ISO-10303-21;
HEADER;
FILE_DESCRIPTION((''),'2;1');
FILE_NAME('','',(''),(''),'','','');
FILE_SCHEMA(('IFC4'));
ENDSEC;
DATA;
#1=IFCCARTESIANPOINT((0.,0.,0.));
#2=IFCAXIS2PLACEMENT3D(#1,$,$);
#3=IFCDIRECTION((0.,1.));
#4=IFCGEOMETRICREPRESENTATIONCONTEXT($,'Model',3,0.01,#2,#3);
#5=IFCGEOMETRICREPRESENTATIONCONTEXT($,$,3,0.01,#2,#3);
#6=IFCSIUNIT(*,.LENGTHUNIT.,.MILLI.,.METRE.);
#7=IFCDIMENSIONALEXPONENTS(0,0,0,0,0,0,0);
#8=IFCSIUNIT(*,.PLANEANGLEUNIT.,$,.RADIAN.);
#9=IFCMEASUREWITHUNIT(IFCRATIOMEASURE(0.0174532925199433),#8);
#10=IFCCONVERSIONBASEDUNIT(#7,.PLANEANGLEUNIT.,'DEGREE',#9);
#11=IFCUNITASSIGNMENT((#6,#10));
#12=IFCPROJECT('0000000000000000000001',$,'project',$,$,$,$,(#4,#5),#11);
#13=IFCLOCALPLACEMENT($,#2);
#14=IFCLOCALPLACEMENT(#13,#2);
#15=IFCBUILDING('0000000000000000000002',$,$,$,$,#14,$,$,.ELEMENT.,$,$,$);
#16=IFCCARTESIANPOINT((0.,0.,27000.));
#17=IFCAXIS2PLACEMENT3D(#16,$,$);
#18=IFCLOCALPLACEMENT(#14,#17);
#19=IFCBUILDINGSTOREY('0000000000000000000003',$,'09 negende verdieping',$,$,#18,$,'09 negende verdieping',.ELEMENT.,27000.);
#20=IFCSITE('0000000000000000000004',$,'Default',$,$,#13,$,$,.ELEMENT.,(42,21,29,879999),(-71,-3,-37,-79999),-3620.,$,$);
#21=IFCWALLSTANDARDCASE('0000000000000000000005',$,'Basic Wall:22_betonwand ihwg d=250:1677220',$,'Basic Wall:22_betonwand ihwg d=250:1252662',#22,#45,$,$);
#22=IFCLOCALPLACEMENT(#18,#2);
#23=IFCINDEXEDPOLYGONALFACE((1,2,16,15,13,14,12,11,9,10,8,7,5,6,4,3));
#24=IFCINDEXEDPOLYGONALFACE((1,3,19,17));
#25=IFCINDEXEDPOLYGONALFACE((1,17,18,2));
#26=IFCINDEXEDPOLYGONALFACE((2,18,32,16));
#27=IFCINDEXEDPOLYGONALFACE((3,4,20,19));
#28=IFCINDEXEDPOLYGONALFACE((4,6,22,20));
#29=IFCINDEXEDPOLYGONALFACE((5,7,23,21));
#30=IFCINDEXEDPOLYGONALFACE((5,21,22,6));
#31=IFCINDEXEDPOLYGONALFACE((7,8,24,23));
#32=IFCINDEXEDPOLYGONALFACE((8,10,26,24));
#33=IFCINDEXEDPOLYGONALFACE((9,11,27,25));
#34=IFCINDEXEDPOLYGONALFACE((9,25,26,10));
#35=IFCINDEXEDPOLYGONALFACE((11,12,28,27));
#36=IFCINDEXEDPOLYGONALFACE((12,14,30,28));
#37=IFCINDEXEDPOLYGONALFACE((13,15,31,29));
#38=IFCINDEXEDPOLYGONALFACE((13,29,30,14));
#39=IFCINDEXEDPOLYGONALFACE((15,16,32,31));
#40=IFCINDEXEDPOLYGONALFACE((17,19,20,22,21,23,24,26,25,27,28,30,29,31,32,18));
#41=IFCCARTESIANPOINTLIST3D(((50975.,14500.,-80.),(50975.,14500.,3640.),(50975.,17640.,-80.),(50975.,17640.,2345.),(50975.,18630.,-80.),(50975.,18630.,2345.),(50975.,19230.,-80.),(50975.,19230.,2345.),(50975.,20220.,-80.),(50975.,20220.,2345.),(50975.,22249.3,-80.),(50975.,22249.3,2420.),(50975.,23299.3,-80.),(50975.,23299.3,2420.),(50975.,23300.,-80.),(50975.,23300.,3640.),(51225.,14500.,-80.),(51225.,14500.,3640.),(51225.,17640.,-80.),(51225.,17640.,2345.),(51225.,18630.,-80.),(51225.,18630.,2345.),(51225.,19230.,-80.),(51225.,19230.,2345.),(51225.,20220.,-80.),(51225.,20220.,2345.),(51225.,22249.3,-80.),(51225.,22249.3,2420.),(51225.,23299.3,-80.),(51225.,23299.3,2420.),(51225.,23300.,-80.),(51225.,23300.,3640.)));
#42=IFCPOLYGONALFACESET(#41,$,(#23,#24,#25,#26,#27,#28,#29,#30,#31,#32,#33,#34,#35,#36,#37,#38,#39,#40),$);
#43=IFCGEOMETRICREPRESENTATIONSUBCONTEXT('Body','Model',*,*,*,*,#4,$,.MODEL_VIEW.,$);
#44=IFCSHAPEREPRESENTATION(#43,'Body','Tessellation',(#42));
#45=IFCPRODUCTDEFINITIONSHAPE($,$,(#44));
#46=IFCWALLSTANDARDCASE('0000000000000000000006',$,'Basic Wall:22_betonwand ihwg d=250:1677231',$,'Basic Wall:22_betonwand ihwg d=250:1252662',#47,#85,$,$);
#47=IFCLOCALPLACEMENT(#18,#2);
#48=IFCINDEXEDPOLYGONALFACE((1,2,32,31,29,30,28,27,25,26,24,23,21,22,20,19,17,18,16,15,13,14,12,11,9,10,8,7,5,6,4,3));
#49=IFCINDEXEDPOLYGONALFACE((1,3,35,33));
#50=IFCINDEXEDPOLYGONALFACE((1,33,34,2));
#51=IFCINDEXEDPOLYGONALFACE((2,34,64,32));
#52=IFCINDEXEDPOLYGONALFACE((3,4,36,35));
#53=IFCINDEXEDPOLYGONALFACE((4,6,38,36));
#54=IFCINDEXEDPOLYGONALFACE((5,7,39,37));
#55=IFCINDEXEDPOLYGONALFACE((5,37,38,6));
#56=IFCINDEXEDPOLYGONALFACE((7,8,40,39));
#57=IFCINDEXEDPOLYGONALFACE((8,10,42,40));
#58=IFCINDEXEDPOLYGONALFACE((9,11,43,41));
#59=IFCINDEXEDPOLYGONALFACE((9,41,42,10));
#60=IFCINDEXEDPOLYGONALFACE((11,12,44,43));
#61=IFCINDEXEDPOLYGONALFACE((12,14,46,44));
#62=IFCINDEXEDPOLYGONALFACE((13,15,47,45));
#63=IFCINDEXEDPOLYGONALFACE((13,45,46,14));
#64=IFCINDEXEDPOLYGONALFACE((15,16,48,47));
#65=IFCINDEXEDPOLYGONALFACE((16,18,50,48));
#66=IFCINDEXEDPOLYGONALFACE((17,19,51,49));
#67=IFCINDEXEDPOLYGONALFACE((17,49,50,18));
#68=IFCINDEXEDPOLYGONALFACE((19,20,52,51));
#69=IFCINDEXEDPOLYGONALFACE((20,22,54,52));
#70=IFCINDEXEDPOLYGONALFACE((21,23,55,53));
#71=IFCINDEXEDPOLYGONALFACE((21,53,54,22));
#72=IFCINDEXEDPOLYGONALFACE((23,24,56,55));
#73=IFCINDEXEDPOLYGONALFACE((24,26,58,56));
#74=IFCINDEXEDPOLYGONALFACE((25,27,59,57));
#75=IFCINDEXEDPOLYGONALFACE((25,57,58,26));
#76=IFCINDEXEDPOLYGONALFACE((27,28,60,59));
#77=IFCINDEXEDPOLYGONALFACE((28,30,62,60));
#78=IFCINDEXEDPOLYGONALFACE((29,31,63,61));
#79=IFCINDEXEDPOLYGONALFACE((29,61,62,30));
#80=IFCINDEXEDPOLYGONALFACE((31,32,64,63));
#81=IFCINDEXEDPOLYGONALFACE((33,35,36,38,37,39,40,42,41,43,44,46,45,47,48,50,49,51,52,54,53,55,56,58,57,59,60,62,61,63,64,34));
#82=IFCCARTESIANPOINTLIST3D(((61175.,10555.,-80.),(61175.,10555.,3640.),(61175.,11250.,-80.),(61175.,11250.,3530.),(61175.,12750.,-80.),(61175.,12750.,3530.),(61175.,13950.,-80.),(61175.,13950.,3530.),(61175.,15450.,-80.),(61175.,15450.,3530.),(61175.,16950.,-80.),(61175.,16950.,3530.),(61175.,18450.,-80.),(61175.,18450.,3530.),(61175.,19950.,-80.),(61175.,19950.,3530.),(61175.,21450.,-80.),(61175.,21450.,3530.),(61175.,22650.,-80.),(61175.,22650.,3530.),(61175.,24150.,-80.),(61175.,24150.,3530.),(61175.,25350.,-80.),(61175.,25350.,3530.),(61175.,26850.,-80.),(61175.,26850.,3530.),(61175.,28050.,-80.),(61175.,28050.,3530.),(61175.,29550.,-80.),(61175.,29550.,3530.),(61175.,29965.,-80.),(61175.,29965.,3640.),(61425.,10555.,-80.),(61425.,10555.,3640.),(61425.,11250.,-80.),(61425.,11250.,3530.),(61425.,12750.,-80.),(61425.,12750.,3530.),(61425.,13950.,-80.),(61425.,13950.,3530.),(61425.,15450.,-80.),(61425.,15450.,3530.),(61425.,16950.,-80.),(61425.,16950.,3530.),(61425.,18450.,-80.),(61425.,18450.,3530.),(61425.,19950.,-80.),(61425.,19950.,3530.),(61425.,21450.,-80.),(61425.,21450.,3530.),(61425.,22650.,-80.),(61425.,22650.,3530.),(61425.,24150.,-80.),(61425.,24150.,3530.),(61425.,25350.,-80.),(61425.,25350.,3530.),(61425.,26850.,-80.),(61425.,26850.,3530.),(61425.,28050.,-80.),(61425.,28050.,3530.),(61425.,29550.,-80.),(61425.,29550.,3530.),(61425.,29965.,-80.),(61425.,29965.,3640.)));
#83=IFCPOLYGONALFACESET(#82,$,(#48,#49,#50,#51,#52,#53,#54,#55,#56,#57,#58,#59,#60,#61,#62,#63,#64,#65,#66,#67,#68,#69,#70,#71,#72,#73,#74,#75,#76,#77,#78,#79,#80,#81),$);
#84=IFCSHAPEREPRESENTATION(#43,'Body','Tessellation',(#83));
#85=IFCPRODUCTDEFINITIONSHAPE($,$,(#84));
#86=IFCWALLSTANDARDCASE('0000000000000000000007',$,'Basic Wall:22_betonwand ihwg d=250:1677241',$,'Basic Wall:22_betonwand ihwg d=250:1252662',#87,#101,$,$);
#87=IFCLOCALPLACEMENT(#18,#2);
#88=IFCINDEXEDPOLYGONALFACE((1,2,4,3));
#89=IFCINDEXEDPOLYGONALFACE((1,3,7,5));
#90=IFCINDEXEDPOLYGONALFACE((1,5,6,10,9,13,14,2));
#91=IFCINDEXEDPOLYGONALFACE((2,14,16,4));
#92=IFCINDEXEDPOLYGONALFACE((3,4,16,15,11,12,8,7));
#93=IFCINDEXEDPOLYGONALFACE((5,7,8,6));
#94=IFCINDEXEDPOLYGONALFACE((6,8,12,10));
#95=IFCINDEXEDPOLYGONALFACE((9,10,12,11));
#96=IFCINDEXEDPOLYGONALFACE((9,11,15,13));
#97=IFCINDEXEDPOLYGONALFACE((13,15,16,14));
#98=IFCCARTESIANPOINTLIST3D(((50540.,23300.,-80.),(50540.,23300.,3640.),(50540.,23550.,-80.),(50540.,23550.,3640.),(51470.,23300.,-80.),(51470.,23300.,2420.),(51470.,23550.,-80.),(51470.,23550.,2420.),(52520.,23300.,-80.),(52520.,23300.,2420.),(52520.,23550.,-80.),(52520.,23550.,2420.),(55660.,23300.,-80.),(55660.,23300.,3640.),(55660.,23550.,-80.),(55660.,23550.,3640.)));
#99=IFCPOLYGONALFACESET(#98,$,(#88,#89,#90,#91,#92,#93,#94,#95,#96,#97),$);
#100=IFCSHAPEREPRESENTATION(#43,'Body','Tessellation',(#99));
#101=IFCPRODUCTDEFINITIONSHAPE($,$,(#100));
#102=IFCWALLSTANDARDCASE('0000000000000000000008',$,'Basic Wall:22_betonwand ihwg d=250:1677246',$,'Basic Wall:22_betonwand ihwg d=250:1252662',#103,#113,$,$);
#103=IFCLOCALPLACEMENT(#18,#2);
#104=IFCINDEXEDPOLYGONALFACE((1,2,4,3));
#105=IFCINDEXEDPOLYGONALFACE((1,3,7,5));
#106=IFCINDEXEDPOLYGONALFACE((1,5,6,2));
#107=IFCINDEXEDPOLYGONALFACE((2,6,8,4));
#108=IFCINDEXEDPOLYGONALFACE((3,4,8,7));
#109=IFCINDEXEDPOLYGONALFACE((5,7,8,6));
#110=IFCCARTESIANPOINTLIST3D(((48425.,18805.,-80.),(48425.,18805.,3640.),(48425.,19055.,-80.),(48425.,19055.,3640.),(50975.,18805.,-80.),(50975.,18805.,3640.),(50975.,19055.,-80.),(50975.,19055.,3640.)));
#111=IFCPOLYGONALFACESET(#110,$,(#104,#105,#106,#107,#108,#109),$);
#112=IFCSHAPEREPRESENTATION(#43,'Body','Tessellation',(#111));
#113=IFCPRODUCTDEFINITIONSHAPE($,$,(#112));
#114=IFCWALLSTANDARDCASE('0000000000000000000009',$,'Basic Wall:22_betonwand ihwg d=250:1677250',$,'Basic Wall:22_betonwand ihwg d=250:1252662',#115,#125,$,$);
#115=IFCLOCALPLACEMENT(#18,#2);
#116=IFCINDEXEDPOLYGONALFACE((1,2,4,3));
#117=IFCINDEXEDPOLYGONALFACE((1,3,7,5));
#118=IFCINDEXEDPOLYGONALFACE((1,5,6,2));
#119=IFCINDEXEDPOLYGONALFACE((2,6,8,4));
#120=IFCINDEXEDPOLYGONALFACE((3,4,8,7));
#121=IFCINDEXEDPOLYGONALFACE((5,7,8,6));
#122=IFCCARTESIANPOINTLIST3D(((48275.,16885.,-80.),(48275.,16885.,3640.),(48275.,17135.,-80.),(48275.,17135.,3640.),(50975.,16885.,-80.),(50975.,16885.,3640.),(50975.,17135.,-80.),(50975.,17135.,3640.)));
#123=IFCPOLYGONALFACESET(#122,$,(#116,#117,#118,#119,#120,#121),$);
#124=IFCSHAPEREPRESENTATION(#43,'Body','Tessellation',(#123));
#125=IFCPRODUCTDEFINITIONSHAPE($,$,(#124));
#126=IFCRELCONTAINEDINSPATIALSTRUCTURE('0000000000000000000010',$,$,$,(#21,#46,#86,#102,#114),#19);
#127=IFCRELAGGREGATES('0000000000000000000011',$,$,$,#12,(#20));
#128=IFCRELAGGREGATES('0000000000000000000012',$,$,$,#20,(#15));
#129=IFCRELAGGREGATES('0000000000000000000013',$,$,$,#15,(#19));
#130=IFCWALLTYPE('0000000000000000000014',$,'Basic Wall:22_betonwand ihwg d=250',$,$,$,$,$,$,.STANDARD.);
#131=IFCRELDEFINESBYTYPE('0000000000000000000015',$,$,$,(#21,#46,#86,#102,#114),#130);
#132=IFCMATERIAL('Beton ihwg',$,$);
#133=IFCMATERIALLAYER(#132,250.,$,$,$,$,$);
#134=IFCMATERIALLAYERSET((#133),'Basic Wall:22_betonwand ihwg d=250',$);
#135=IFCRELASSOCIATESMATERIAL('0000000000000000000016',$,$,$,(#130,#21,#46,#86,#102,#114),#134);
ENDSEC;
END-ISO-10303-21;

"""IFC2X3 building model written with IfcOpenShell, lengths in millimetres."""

from ifc_helpers import new_model, entity, si_unit, converted_unit, direction, frame, frame_2d, origin, place, context, subcontext, project, spatial, rectangle, extrude, material, layer, layer_set, layer_usage, type_object, element, save


model = new_model("IFC2X3")

# Units and contexts
model_context = context("Model", 3, precision=0.01, world=origin(), true_north=direction((0.0, 1.0)))
context_of_model = context(None, 3, precision=0.01, world=origin(), true_north=direction((0.0, 1.0)))
body_context = subcontext(model_context, "Body", "Model", "MODEL_VIEW")
ifc_project = project(units=[si_unit("LENGTHUNIT", "METRE", prefix="MILLI"), converted_unit("PLANEANGLEUNIT", "DEGREE", entity("IfcRatioMeasure", 0.0174532925199433), si_unit("PLANEANGLEUNIT", "RADIAN"), dimensions=[0, 0, 0, 0, 0, 0, 0])], contexts=[model_context, context_of_model])

# Site, building, storey
site_placement = place(None, origin())
site = spatial("IfcSite", under=ifc_project, at=site_placement, Name="Default", CompositionType="ELEMENT", RefLatitude=(42, 21, 29, 879999), RefLongitude=(-71, -3, -37, -79999), RefElevation=-3620.0)
building_placement = place(site_placement, origin())
building = spatial("IfcBuilding", under=site, at=building_placement, CompositionType="ELEMENT")
storey_placement = place(building_placement, frame((0.0, 0.0, 27000.0)))
storey = spatial("IfcBuildingStorey", under=building, at=storey_placement, Name="09 negende verdieping", LongName="09 negende verdieping", CompositionType="ELEMENT", Elevation=27000.0)

# Walls, openings
ifc_material_1 = material(Name="Beton ihwg")
ifc_layer_1 = layer(ifc_material_1, 250.0)
ifc_layer_set_1 = layer_set([ifc_layer_1], Name="Basic Wall:22_betonwand ihwg d=250")
ifc_layer_usage_1 = layer_usage(ifc_layer_set_1, "AXIS2", "NEGATIVE", 125.0)
wall_type_1 = type_object("IfcWallType", Name="Basic Wall:22_betonwand ihwg d=250", PredefinedType="STANDARD", material=ifc_layer_set_1)
wall_1_placement = place(storey_placement, frame((51100.0, 23300.0, -80.0), z_axis=(0.0, 0.0, 1.0), x_axis=(0.0, -1.0, 0.0)))
wall_1 = element("IfcWallStandardCase", 1, at=wall_1_placement, inside=storey, type_object=wall_type_1, material=ifc_layer_usage_1, Name="Basic Wall:22_betonwand ihwg d=250:1677220", ObjectType="Basic Wall:22_betonwand ihwg d=250:1252662", context=body_context, shape_type="SweptSolid", body=[
    extrude(rectangle(XDim=8800.0, YDim=250.0, at=frame_2d((4400.0, 0.0), x_axis=(-1.0, 0.0))), origin(), (0.0, 0.0, 1.0), 3720.0),
])
opening_1_placement = place(wall_1_placement, frame((23300.0, -51100.0, 80.0), z_axis=(0.0, 0.0, 1.0), x_axis=(0.0, 1.0, 0.0)))
element("IfcOpeningElement", 2, at=opening_1_placement, cuts=wall_1, ObjectType="Opening", context=body_context, shape_type="SweptSolid", body=[
    extrude(rectangle(XDim=2425.0, YDim=990.0, at=frame_2d((0.0, 0.0), x_axis=(1.0, 0.0))), frame((50700.0, 19725.0, 1132.5), z_axis=(1.0, 0.0, 0.0), x_axis=(0.0, 0.0, -1.0)), (0.0, 0.0, 1.0), 800.0),
])
opening_2_placement = place(wall_1_placement, frame((23300.0, -51100.0, 80.0), z_axis=(0.0, 0.0, 1.0), x_axis=(0.0, 1.0, 0.0)))
element("IfcOpeningElement", 3, at=opening_2_placement, cuts=wall_1, ObjectType="Opening", context=body_context, shape_type="SweptSolid", body=[
    extrude(rectangle(XDim=2425.0, YDim=990.0, at=frame_2d((0.0, 0.0), x_axis=(1.0, 0.0))), frame((50700.0, 18135.0, 1132.5), z_axis=(1.0, 0.0, 0.0), x_axis=(0.0, 0.0, -1.0)), (0.0, 0.0, 1.0), 800.0),
])
opening_3_placement = place(wall_1_placement, frame((23300.0, -51100.0, 80.0), z_axis=(0.0, 0.0, 1.0), x_axis=(0.0, 1.0, 0.0)))
element("IfcOpeningElement", 4, at=opening_3_placement, cuts=wall_1, ObjectType="Opening", context=body_context, shape_type="SweptSolid", body=[
    extrude(rectangle(XDim=2500.0, YDim=1050.0, at=frame_2d((0.0, 0.0), x_axis=(1.0, 0.0))), frame((50700.0, 22774.3, 1170.0), z_axis=(1.0, 0.0, 0.0), x_axis=(0.0, 0.0, -1.0)), (0.0, 0.0, 1.0), 800.0),
])
ifc_layer_usage_2 = layer_usage(ifc_layer_set_1, "AXIS2", "POSITIVE", -125.0)
wall_2_placement = place(storey_placement, frame((61300.0, 29965.0, -80.0), z_axis=(0.0, 0.0, 1.0), x_axis=(0.0, -1.0, 0.0)))
wall_2 = element("IfcWallStandardCase", 5, at=wall_2_placement, inside=storey, type_object=wall_type_1, material=ifc_layer_usage_2, Name="Basic Wall:22_betonwand ihwg d=250:1677231", ObjectType="Basic Wall:22_betonwand ihwg d=250:1252662", context=body_context, shape_type="SweptSolid", body=[
    extrude(rectangle(XDim=19410.0, YDim=250.0, at=frame_2d((9705.0, 0.0), x_axis=(-1.0, 0.0))), origin(), (0.0, 0.0, 1.0), 3720.0),
])
opening_4_placement = place(wall_2_placement, frame((29965.0, -61300.0, 80.0), z_axis=(0.0, 0.0, 1.0), x_axis=(0.0, 1.0, 0.0)))
element("IfcOpeningElement", 6, at=opening_4_placement, cuts=wall_2, ObjectType="Opening", context=body_context, shape_type="SweptSolid", body=[
    extrude(rectangle(XDim=3610.0, YDim=1500.0, at=frame_2d((0.0, 0.0), x_axis=(1.0, 0.0))), frame((59901.0, 28800.0, 1725.0), z_axis=(1.0, 0.0, 0.0), x_axis=(0.0, 0.0, -1.0)), (0.0, 0.0, 1.0), 3048.0),
])
opening_5_placement = place(wall_2_placement, frame((29965.0, -61300.0, 80.0), z_axis=(0.0, 0.0, 1.0), x_axis=(0.0, 1.0, 0.0)))
element("IfcOpeningElement", 7, at=opening_5_placement, cuts=wall_2, ObjectType="Opening", context=body_context, shape_type="SweptSolid", body=[
    extrude(rectangle(XDim=3610.0, YDim=1500.0, at=frame_2d((0.0, 0.0), x_axis=(1.0, 0.0))), frame((59901.0, 26100.0, 1725.0), z_axis=(1.0, 0.0, 0.0), x_axis=(0.0, 0.0, -1.0)), (0.0, 0.0, 1.0), 3048.0),
])
opening_6_placement = place(wall_2_placement, frame((29965.0, -61300.0, 80.0), z_axis=(0.0, 0.0, 1.0), x_axis=(0.0, 1.0, 0.0)))
element("IfcOpeningElement", 8, at=opening_6_placement, cuts=wall_2, ObjectType="Opening", context=body_context, shape_type="SweptSolid", body=[
    extrude(rectangle(XDim=3610.0, YDim=1500.0, at=frame_2d((0.0, 0.0), x_axis=(1.0, 0.0))), frame((59901.0, 23400.0, 1725.0), z_axis=(1.0, 0.0, 0.0), x_axis=(0.0, 0.0, -1.0)), (0.0, 0.0, 1.0), 3048.0),
])
opening_7_placement = place(wall_2_placement, frame((29965.0, -61300.0, 80.0), z_axis=(0.0, 0.0, 1.0), x_axis=(0.0, 1.0, 0.0)))
element("IfcOpeningElement", 9, at=opening_7_placement, cuts=wall_2, ObjectType="Opening", context=body_context, shape_type="SweptSolid", body=[
    extrude(rectangle(XDim=3610.0, YDim=1500.0, at=frame_2d((0.0, 0.0), x_axis=(1.0, 0.0))), frame((59901.0, 17700.0, 1725.0), z_axis=(1.0, 0.0, 0.0), x_axis=(0.0, 0.0, -1.0)), (0.0, 0.0, 1.0), 3048.0),
])
opening_8_placement = place(wall_2_placement, frame((29965.0, -61300.0, 80.0), z_axis=(0.0, 0.0, 1.0), x_axis=(0.0, 1.0, 0.0)))
element("IfcOpeningElement", 10, at=opening_8_placement, cuts=wall_2, ObjectType="Opening", context=body_context, shape_type="SweptSolid", body=[
    extrude(rectangle(XDim=3610.0, YDim=1500.0, at=frame_2d((0.0, 0.0), x_axis=(1.0, 0.0))), frame((59901.0, 14700.0, 1725.0), z_axis=(1.0, 0.0, 0.0), x_axis=(0.0, 0.0, -1.0)), (0.0, 0.0, 1.0), 3048.0),
])
opening_9_placement = place(wall_2_placement, frame((29965.0, -61300.0, 80.0), z_axis=(0.0, 0.0, 1.0), x_axis=(0.0, 1.0, 0.0)))
element("IfcOpeningElement", 11, at=opening_9_placement, cuts=wall_2, ObjectType="Opening", context=body_context, shape_type="SweptSolid", body=[
    extrude(rectangle(XDim=3610.0, YDim=1500.0, at=frame_2d((0.0, 0.0), x_axis=(1.0, 0.0))), frame((59901.0, 20700.0, 1725.0), z_axis=(1.0, 0.0, 0.0), x_axis=(0.0, 0.0, -1.0)), (0.0, 0.0, 1.0), 3048.0),
])
opening_10_placement = place(wall_2_placement, frame((29965.0, -61300.0, 80.0), z_axis=(0.0, 0.0, 1.0), x_axis=(0.0, 1.0, 0.0)))
element("IfcOpeningElement", 12, at=opening_10_placement, cuts=wall_2, ObjectType="Opening", context=body_context, shape_type="SweptSolid", body=[
    extrude(rectangle(XDim=3610.0, YDim=1500.0, at=frame_2d((0.0, 0.0), x_axis=(1.0, 0.0))), frame((59901.0, 12000.0, 1725.0), z_axis=(1.0, 0.0, 0.0), x_axis=(0.0, 0.0, -1.0)), (0.0, 0.0, 1.0), 3048.0),
])
ifc_layer_usage_3 = layer_usage(ifc_layer_set_1, "AXIS2", "POSITIVE", -125.0)
wall_3_placement = place(storey_placement, frame((55660.0, 23425.0, -80.0), z_axis=(0.0, 0.0, 1.0), x_axis=(-1.0, 0.0, 0.0)))
wall_3 = element("IfcWallStandardCase", 13, at=wall_3_placement, inside=storey, type_object=wall_type_1, material=ifc_layer_usage_3, Name="Basic Wall:22_betonwand ihwg d=250:1677241", ObjectType="Basic Wall:22_betonwand ihwg d=250:1252662", context=body_context, shape_type="SweptSolid", body=[
    extrude(rectangle(XDim=5120.0, YDim=250.0, at=frame_2d((2560.0, 0.0), x_axis=(-1.0, 0.0))), origin(), (0.0, 0.0, 1.0), 3720.0),
])
opening_11_placement = place(wall_3_placement, origin())
element("IfcOpeningElement", 14, at=opening_11_placement, cuts=wall_3, ObjectType="Opening", context=body_context, shape_type="SweptSolid", body=[
    extrude(rectangle(XDim=2500.0, YDim=800.0, at=frame_2d((0.0, 0.0), x_axis=(0.0, 1.0))), frame((2735.0, 125.0, 1250.0), z_axis=(0.0, 1.0, 0.0), x_axis=(1.0, 0.0, 0.0)), (0.0, 0.0, 1.0), 1034.0),
])
opening_12_placement = place(wall_3_placement, frame((55660.0, 23425.0, 80.0), z_axis=(0.0, 0.0, 1.0), x_axis=(-1.0, 0.0, 0.0)))
element("IfcOpeningElement", 15, at=opening_12_placement, cuts=wall_3, ObjectType="Opening", context=body_context, shape_type="SweptSolid", body=[
    extrude(rectangle(XDim=2500.0, YDim=1050.0, at=frame_2d((0.0, 0.0), x_axis=(0.0, 1.0))), frame((51995.0, 23825.0, 1170.0), z_axis=(0.0, -1.0, 0.0), x_axis=(-1.0, 0.0, 0.0)), (0.0, 0.0, 1.0), 800.0),
])

# Walls
ifc_layer_usage_4 = layer_usage(ifc_layer_set_1, "AXIS2", "POSITIVE", -125.0)
wall_4_placement = place(storey_placement, frame((50975.0, 18930.0, -80.0), z_axis=(0.0, 0.0, 1.0), x_axis=(-1.0, 0.0, 0.0)))
element("IfcWallStandardCase", 16, at=wall_4_placement, inside=storey, type_object=wall_type_1, material=ifc_layer_usage_4, Name="Basic Wall:22_betonwand ihwg d=250:1677246", ObjectType="Basic Wall:22_betonwand ihwg d=250:1252662", context=body_context, shape_type="SweptSolid", body=[
    extrude(rectangle(XDim=2550.0, YDim=250.0, at=frame_2d((1275.0, 0.0), x_axis=(-1.0, 0.0))), origin(), (0.0, 0.0, 1.0), 3720.0),
])
ifc_layer_usage_5 = layer_usage(ifc_layer_set_1, "AXIS2", "POSITIVE", -125.0)
wall_5_placement = place(storey_placement, frame((50975.0, 17010.0, -80.0), z_axis=(0.0, 0.0, 1.0), x_axis=(-1.0, 0.0, 0.0)))
element("IfcWallStandardCase", 17, at=wall_5_placement, inside=storey, type_object=wall_type_1, material=ifc_layer_usage_5, Name="Basic Wall:22_betonwand ihwg d=250:1677250", ObjectType="Basic Wall:22_betonwand ihwg d=250:1252662", context=body_context, shape_type="SweptSolid", body=[
    extrude(rectangle(XDim=2700.0, YDim=250.0, at=frame_2d((1350.0, 0.0), x_axis=(-1.0, 0.0))), origin(), (0.0, 0.0, 1.0), 3720.0),
])

save(model, "model.ifc")
